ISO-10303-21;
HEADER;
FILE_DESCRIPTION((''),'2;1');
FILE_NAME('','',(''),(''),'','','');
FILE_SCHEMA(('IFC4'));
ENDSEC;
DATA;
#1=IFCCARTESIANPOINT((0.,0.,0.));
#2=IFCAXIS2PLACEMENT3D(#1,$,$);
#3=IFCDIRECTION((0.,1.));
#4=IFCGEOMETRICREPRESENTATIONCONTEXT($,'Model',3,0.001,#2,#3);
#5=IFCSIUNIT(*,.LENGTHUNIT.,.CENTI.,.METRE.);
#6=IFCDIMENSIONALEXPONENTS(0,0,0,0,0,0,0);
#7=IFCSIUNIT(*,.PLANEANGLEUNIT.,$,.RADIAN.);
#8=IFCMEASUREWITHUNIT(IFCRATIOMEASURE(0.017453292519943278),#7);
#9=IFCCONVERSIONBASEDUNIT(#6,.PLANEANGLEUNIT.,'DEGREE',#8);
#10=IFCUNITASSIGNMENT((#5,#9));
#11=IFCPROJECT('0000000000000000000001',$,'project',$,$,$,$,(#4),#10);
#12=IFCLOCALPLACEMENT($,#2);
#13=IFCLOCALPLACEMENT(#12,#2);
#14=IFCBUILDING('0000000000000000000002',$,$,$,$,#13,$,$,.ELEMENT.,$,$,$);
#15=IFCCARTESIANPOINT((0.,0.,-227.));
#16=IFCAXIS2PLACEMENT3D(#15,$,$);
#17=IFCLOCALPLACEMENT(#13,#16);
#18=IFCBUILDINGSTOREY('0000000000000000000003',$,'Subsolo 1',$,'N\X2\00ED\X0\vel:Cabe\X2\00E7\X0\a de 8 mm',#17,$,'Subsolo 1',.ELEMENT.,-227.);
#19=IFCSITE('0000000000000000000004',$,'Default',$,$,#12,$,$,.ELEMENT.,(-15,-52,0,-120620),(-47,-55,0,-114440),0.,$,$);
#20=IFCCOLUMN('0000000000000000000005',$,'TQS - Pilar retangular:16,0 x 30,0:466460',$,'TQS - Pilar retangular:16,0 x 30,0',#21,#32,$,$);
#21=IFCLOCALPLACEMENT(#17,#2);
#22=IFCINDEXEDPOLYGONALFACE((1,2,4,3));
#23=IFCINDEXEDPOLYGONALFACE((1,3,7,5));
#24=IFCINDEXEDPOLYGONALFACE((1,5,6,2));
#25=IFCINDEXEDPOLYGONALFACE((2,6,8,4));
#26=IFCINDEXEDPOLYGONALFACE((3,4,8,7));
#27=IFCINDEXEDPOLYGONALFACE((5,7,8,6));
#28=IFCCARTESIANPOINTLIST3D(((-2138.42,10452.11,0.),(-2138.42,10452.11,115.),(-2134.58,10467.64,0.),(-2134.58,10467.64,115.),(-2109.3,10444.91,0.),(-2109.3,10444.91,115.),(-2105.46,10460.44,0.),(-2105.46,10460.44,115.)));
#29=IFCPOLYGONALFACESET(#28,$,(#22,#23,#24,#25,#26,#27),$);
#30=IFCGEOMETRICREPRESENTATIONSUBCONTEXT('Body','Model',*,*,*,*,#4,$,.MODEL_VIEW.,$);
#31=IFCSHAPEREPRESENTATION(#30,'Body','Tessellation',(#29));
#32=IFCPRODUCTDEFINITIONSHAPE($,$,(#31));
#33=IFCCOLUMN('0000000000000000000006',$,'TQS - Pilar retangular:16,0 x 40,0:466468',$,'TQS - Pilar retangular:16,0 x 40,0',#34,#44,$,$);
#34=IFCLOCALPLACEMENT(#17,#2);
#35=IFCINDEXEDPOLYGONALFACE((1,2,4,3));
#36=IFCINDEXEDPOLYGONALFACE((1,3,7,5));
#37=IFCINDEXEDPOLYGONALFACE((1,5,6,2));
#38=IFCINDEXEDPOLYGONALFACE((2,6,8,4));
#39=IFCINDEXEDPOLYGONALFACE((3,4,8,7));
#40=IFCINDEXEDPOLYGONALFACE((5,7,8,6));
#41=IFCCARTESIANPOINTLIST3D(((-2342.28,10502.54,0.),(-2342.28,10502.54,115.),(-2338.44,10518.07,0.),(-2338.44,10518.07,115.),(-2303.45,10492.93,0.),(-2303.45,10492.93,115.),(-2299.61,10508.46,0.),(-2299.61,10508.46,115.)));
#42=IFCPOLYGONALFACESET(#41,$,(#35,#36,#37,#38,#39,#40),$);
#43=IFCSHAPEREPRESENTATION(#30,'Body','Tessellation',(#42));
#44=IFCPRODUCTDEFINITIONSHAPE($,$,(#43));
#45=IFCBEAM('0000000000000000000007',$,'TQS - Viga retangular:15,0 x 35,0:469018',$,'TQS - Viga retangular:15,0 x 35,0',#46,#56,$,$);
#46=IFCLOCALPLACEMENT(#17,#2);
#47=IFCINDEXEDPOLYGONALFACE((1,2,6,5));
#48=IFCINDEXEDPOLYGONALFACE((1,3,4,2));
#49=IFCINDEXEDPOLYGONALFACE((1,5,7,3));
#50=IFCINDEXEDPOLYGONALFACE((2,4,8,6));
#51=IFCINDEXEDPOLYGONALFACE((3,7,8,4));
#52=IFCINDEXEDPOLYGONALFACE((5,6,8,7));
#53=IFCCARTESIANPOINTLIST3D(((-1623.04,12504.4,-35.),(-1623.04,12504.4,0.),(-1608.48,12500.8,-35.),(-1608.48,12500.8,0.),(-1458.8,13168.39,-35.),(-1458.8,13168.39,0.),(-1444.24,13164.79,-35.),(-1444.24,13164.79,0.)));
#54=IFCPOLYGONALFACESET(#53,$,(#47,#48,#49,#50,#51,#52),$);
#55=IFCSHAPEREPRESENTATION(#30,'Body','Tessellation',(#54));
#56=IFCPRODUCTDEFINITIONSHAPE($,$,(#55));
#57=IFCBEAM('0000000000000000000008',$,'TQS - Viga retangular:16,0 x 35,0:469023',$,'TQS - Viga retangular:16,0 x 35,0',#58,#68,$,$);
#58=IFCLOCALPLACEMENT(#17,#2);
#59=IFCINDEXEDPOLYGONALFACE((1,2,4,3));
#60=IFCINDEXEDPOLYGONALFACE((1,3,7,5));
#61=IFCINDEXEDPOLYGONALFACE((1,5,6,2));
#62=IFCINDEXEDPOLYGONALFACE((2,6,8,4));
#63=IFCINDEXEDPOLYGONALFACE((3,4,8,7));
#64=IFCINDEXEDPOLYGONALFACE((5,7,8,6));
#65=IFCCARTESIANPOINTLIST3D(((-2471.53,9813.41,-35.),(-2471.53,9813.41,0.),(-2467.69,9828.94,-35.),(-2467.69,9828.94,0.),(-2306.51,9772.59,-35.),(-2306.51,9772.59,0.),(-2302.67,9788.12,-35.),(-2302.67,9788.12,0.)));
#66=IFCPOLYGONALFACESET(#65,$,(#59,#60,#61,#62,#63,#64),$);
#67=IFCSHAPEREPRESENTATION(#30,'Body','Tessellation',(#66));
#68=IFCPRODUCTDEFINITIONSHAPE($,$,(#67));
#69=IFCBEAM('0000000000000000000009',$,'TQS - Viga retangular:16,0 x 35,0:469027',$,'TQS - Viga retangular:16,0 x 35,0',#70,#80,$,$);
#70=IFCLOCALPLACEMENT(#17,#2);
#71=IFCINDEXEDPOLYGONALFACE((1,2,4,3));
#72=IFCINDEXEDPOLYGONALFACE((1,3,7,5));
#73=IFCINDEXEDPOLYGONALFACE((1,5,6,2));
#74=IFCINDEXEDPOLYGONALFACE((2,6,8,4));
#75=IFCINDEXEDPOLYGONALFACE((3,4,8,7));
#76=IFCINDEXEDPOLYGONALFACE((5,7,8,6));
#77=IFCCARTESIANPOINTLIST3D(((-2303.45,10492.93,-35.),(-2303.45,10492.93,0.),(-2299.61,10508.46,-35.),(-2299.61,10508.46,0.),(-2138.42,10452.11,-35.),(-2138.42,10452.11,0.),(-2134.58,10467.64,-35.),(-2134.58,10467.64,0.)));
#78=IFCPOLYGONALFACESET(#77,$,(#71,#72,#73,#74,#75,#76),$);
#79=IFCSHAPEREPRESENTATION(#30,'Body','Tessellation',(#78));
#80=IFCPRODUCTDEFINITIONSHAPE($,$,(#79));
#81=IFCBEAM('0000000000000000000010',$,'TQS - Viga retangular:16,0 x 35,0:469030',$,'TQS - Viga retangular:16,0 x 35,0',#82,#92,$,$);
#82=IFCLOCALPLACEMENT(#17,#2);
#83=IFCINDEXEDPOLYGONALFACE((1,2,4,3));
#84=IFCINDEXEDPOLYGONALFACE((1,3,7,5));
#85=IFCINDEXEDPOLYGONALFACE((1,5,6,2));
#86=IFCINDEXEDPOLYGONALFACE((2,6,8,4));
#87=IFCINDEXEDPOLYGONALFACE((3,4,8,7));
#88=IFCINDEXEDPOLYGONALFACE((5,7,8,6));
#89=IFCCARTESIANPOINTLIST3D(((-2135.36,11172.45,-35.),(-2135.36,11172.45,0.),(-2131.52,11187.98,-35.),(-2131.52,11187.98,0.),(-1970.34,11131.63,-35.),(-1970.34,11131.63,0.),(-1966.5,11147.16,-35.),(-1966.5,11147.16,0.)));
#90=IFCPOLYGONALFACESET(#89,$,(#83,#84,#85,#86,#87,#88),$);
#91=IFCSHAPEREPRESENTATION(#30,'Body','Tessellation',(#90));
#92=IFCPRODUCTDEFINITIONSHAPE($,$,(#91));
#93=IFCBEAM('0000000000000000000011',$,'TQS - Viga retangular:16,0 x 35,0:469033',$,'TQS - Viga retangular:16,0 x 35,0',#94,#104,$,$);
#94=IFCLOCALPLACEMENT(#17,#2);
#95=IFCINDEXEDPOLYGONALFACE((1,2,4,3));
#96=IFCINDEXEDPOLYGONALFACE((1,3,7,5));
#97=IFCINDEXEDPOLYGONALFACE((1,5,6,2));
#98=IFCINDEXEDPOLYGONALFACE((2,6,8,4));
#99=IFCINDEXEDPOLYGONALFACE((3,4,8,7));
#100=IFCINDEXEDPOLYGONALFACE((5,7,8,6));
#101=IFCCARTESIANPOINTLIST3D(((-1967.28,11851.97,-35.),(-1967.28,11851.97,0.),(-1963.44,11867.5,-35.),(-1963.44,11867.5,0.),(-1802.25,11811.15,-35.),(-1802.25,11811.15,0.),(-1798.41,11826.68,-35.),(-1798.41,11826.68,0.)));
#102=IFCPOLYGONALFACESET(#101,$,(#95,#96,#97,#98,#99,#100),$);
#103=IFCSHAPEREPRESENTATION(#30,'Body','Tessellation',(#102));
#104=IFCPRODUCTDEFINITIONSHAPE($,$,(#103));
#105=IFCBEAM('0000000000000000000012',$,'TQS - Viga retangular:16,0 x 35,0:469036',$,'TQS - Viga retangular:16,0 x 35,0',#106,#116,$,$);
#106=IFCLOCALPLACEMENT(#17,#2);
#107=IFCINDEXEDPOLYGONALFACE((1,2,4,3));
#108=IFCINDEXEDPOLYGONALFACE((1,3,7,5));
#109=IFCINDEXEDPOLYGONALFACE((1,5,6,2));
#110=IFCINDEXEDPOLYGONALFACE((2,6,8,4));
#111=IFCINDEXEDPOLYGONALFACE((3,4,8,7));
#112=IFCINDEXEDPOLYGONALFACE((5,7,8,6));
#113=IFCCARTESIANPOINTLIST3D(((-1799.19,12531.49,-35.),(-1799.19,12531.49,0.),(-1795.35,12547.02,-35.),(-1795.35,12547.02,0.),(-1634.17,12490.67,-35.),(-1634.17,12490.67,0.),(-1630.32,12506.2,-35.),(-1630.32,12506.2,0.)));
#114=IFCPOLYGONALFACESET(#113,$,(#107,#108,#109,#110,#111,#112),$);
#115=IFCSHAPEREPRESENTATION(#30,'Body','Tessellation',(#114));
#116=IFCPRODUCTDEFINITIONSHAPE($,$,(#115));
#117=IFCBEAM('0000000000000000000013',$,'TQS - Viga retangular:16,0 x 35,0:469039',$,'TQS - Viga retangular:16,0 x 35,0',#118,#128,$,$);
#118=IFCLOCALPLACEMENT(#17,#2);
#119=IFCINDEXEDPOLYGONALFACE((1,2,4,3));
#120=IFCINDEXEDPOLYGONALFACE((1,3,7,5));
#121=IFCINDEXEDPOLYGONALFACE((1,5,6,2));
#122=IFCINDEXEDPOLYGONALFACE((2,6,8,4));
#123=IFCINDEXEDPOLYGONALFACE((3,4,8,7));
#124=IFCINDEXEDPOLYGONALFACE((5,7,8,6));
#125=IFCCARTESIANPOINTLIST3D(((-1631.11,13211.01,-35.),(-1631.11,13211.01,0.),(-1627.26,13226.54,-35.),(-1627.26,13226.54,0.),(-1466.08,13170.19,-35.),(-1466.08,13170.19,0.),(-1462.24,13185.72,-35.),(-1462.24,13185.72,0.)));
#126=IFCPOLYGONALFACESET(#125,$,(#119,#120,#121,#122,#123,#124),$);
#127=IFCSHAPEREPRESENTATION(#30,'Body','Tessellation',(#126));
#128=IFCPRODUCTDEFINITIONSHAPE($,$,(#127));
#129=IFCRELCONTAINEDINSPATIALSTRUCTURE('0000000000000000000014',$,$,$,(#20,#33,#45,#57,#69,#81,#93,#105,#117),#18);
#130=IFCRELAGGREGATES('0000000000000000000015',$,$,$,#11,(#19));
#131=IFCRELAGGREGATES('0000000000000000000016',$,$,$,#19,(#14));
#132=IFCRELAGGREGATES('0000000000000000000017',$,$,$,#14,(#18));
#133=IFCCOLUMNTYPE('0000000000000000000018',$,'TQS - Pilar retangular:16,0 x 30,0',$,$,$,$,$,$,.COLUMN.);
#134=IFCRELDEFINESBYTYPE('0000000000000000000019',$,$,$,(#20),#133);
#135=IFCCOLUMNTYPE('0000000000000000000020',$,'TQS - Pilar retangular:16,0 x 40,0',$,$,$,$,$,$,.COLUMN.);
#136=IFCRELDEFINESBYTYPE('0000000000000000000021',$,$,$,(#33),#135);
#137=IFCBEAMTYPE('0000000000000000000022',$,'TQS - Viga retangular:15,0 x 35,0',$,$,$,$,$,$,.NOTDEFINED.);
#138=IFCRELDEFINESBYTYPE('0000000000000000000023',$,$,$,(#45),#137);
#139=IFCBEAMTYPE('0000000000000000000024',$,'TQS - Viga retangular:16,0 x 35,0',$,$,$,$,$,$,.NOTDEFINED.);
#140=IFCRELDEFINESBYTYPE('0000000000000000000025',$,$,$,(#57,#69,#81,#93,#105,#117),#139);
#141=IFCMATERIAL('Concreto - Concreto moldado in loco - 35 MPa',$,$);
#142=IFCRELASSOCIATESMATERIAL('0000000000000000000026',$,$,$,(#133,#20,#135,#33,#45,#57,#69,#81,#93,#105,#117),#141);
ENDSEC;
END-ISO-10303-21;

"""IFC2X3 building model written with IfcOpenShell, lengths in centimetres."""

from ifc_helpers import new_model, entity, si_unit, converted_unit, direction, frame, frame_2d, origin, origin_2d_with_axis, place, context, subcontext, project, spatial, rectangle, extrude, source, transform, mapped, material, type_object, type_shapes, element, save


model = new_model("IFC2X3")

# Units and contexts
model_context = context("Model", 3, precision=0.001, world=origin(), true_north=direction((0.0, 1.0)))
body_context = subcontext(model_context, "Body", "Model", "MODEL_VIEW")
ifc_project = project(units=[si_unit("LENGTHUNIT", "METRE", prefix="CENTI"), converted_unit("PLANEANGLEUNIT", "DEGREE", entity("IfcRatioMeasure", 0.017453292519943278), si_unit("PLANEANGLEUNIT", "RADIAN"), dimensions=[0, 0, 0, 0, 0, 0, 0])], contexts=[model_context])

# Site, building, storey
site_placement = place(None, origin())
site = spatial("IfcSite", under=ifc_project, at=site_placement, Name="Default", CompositionType="ELEMENT", RefLatitude=(-15, -52, 0, -120620), RefLongitude=(-47, -55, 0, -114440), RefElevation=0.0)
building_placement = place(site_placement, origin())
building = spatial("IfcBuilding", under=site, at=building_placement, CompositionType="ELEMENT")
storey_placement = place(building_placement, frame((0.0, 0.0, -227.0)))
storey = spatial("IfcBuildingStorey", under=building, at=storey_placement, Name="Subsolo 1", ObjectType="Nível:Cabeça de 8 mm", LongName="Subsolo 1", CompositionType="ELEMENT", Elevation=-227.0)

# Columns
ifc_material = material(Name="Concreto - Concreto moldado in loco - 35 MPa")
column_type_1 = type_object("IfcColumnType", Name="TQS - Pilar retangular:16,0 x 30,0", PredefinedType="COLUMN", material=ifc_material)
shared_shape_1 = source(origin(), body_context, "Body", "SweptSolid", [
    extrude(rectangle(XDim=30.0, YDim=16.0, at=origin_2d_with_axis()), frame((-2121.94, 10456.27, -227.0), z_axis=(0.0, 0.0, 1.0), x_axis=(-0.970743, 0.240122, 0.0)), (0.0, 0.0, 1.0), 115.0),
])
type_shapes(column_type_1, [shared_shape_1])
column_1_placement = place(storey_placement, frame((0.0, 0.0, 227.0)))
element("IfcColumn", 1, at=column_1_placement, inside=storey, type_object=column_type_1, material=ifc_material, Name="TQS - Pilar retangular:16,0 x 30,0:466460", ObjectType="TQS - Pilar retangular:16,0 x 30,0", context=body_context, shape_type="MappedRepresentation", body=[
    mapped(shared_shape_1, transform((0.0, 0.0, 0.0), scale=1.0)),
])
column_type_2 = type_object("IfcColumnType", Name="TQS - Pilar retangular:16,0 x 40,0", PredefinedType="COLUMN", material=ifc_material)
shared_shape_2 = source(origin(), body_context, "Body", "SweptSolid", [
    extrude(rectangle(XDim=40.0, YDim=16.0, at=origin_2d_with_axis()), frame((-2320.94, 10505.5, -227.0), z_axis=(0.0, 0.0, 1.0), x_axis=(-0.970743, 0.240122, 0.0)), (0.0, 0.0, 1.0), 115.0),
])
type_shapes(column_type_2, [shared_shape_2])
column_2_placement = place(storey_placement, frame((0.0, 0.0, 227.0)))
element("IfcColumn", 2, at=column_2_placement, inside=storey, type_object=column_type_2, material=ifc_material, Name="TQS - Pilar retangular:16,0 x 40,0:466468", ObjectType="TQS - Pilar retangular:16,0 x 40,0", context=body_context, shape_type="MappedRepresentation", body=[
    mapped(shared_shape_2, transform((0.0, 0.0, 0.0), scale=1.0)),
])

# Beams
beam_type_1 = type_object("IfcBeamType", Name="TQS - Viga retangular:15,0 x 35,0", PredefinedType="NOTDEFINED")
beam_1_placement = place(storey_placement, frame((-1615.76, 12502.6, 0.0), z_axis=(0.0, 0.0, 1.0), x_axis=(0.240122, 0.970743, 0.0)))
element("IfcBeam", 3, at=beam_1_placement, inside=storey, type_object=beam_type_1, material=ifc_material, Name="TQS - Viga retangular:15,0 x 35,0:469018", ObjectType="TQS - Viga retangular:15,0 x 35,0", context=body_context, shape_type="SweptSolid", body=[
    extrude(rectangle(XDim=35.0, YDim=15.0, at=frame_2d((0.0, 0.0), x_axis=(1.0, 0.0))), frame((0.0, 0.0, -17.5), z_axis=(1.0, 0.0, 0.0), x_axis=(0.0, 0.0, -1.0)), (0.0, 0.0, 1.0), 684.0),
])
beam_type_2 = type_object("IfcBeamType", Name="TQS - Viga retangular:16,0 x 35,0", PredefinedType="NOTDEFINED")
beam_2_placement = place(storey_placement, frame((-2304.59, 9780.36, 0.0), z_axis=(0.0, 0.0, 1.0), x_axis=(-0.970743, 0.240122, 0.0)))
element("IfcBeam", 4, at=beam_2_placement, inside=storey, type_object=beam_type_2, material=ifc_material, Name="TQS - Viga retangular:16,0 x 35,0:469023", ObjectType="TQS - Viga retangular:16,0 x 35,0", context=body_context, shape_type="SweptSolid", body=[
    extrude(rectangle(XDim=35.0, YDim=16.0, at=frame_2d((0.0, 0.0), x_axis=(1.0, 0.0))), frame((0.0, 0.0, -17.5), z_axis=(1.0, 0.0, 0.0), x_axis=(0.0, 0.0, -1.0)), (0.0, 0.0, 1.0), 170.0),
])
beam_3_placement = place(storey_placement, frame((-2136.5, 10459.88, 0.0), z_axis=(0.0, 0.0, 1.0), x_axis=(-0.970743, 0.240122, 0.0)))
element("IfcBeam", 5, at=beam_3_placement, inside=storey, type_object=beam_type_2, material=ifc_material, Name="TQS - Viga retangular:16,0 x 35,0:469027", ObjectType="TQS - Viga retangular:16,0 x 35,0", context=body_context, shape_type="SweptSolid", body=[
    extrude(rectangle(XDim=35.0, YDim=16.0, at=frame_2d((0.0, 0.0), x_axis=(1.0, 0.0))), frame((0.0, 0.0, -17.5), z_axis=(1.0, 0.0, 0.0), x_axis=(0.0, 0.0, -1.0)), (0.0, 0.0, 1.0), 170.0),
])
beam_4_placement = place(storey_placement, frame((-1968.42, 11139.4, 0.0), z_axis=(0.0, 0.0, 1.0), x_axis=(-0.970743, 0.240122, 0.0)))
element("IfcBeam", 6, at=beam_4_placement, inside=storey, type_object=beam_type_2, material=ifc_material, Name="TQS - Viga retangular:16,0 x 35,0:469030", ObjectType="TQS - Viga retangular:16,0 x 35,0", context=body_context, shape_type="SweptSolid", body=[
    extrude(rectangle(XDim=35.0, YDim=16.0, at=frame_2d((0.0, 0.0), x_axis=(1.0, 0.0))), frame((0.0, 0.0, -17.5), z_axis=(1.0, 0.0, 0.0), x_axis=(0.0, 0.0, -1.0)), (0.0, 0.0, 1.0), 170.0),
])
beam_5_placement = place(storey_placement, frame((-1800.33, 11818.92, 0.0), z_axis=(0.0, 0.0, 1.0), x_axis=(-0.970743, 0.240122, 0.0)))
element("IfcBeam", 7, at=beam_5_placement, inside=storey, type_object=beam_type_2, material=ifc_material, Name="TQS - Viga retangular:16,0 x 35,0:469033", ObjectType="TQS - Viga retangular:16,0 x 35,0", context=body_context, shape_type="SweptSolid", body=[
    extrude(rectangle(XDim=35.0, YDim=16.0, at=frame_2d((0.0, 0.0), x_axis=(1.0, 0.0))), frame((0.0, 0.0, -17.5), z_axis=(1.0, 0.0, 0.0), x_axis=(0.0, 0.0, -1.0)), (0.0, 0.0, 1.0), 170.0),
])
beam_6_placement = place(storey_placement, frame((-1632.25, 12498.44, 0.0), z_axis=(0.0, 0.0, 1.0), x_axis=(-0.970743, 0.240122, 0.0)))
element("IfcBeam", 8, at=beam_6_placement, inside=storey, type_object=beam_type_2, material=ifc_material, Name="TQS - Viga retangular:16,0 x 35,0:469036", ObjectType="TQS - Viga retangular:16,0 x 35,0", context=body_context, shape_type="SweptSolid", body=[
    extrude(rectangle(XDim=35.0, YDim=16.0, at=frame_2d((0.0, 0.0), x_axis=(1.0, 0.0))), frame((0.0, 0.0, -17.5), z_axis=(1.0, 0.0, 0.0), x_axis=(0.0, 0.0, -1.0)), (0.0, 0.0, 1.0), 170.0),
])
beam_7_placement = place(storey_placement, frame((-1464.16, 13177.96, 0.0), z_axis=(0.0, 0.0, 1.0), x_axis=(-0.970743, 0.240122, 0.0)))
element("IfcBeam", 9, at=beam_7_placement, inside=storey, type_object=beam_type_2, material=ifc_material, Name="TQS - Viga retangular:16,0 x 35,0:469039", ObjectType="TQS - Viga retangular:16,0 x 35,0", context=body_context, shape_type="SweptSolid", body=[
    extrude(rectangle(XDim=35.0, YDim=16.0, at=frame_2d((0.0, 0.0), x_axis=(1.0, 0.0))), frame((0.0, 0.0, -17.5), z_axis=(1.0, 0.0, 0.0), x_axis=(0.0, 0.0, -1.0)), (0.0, 0.0, 1.0), 170.0),
])

save(model, "model.ifc")
